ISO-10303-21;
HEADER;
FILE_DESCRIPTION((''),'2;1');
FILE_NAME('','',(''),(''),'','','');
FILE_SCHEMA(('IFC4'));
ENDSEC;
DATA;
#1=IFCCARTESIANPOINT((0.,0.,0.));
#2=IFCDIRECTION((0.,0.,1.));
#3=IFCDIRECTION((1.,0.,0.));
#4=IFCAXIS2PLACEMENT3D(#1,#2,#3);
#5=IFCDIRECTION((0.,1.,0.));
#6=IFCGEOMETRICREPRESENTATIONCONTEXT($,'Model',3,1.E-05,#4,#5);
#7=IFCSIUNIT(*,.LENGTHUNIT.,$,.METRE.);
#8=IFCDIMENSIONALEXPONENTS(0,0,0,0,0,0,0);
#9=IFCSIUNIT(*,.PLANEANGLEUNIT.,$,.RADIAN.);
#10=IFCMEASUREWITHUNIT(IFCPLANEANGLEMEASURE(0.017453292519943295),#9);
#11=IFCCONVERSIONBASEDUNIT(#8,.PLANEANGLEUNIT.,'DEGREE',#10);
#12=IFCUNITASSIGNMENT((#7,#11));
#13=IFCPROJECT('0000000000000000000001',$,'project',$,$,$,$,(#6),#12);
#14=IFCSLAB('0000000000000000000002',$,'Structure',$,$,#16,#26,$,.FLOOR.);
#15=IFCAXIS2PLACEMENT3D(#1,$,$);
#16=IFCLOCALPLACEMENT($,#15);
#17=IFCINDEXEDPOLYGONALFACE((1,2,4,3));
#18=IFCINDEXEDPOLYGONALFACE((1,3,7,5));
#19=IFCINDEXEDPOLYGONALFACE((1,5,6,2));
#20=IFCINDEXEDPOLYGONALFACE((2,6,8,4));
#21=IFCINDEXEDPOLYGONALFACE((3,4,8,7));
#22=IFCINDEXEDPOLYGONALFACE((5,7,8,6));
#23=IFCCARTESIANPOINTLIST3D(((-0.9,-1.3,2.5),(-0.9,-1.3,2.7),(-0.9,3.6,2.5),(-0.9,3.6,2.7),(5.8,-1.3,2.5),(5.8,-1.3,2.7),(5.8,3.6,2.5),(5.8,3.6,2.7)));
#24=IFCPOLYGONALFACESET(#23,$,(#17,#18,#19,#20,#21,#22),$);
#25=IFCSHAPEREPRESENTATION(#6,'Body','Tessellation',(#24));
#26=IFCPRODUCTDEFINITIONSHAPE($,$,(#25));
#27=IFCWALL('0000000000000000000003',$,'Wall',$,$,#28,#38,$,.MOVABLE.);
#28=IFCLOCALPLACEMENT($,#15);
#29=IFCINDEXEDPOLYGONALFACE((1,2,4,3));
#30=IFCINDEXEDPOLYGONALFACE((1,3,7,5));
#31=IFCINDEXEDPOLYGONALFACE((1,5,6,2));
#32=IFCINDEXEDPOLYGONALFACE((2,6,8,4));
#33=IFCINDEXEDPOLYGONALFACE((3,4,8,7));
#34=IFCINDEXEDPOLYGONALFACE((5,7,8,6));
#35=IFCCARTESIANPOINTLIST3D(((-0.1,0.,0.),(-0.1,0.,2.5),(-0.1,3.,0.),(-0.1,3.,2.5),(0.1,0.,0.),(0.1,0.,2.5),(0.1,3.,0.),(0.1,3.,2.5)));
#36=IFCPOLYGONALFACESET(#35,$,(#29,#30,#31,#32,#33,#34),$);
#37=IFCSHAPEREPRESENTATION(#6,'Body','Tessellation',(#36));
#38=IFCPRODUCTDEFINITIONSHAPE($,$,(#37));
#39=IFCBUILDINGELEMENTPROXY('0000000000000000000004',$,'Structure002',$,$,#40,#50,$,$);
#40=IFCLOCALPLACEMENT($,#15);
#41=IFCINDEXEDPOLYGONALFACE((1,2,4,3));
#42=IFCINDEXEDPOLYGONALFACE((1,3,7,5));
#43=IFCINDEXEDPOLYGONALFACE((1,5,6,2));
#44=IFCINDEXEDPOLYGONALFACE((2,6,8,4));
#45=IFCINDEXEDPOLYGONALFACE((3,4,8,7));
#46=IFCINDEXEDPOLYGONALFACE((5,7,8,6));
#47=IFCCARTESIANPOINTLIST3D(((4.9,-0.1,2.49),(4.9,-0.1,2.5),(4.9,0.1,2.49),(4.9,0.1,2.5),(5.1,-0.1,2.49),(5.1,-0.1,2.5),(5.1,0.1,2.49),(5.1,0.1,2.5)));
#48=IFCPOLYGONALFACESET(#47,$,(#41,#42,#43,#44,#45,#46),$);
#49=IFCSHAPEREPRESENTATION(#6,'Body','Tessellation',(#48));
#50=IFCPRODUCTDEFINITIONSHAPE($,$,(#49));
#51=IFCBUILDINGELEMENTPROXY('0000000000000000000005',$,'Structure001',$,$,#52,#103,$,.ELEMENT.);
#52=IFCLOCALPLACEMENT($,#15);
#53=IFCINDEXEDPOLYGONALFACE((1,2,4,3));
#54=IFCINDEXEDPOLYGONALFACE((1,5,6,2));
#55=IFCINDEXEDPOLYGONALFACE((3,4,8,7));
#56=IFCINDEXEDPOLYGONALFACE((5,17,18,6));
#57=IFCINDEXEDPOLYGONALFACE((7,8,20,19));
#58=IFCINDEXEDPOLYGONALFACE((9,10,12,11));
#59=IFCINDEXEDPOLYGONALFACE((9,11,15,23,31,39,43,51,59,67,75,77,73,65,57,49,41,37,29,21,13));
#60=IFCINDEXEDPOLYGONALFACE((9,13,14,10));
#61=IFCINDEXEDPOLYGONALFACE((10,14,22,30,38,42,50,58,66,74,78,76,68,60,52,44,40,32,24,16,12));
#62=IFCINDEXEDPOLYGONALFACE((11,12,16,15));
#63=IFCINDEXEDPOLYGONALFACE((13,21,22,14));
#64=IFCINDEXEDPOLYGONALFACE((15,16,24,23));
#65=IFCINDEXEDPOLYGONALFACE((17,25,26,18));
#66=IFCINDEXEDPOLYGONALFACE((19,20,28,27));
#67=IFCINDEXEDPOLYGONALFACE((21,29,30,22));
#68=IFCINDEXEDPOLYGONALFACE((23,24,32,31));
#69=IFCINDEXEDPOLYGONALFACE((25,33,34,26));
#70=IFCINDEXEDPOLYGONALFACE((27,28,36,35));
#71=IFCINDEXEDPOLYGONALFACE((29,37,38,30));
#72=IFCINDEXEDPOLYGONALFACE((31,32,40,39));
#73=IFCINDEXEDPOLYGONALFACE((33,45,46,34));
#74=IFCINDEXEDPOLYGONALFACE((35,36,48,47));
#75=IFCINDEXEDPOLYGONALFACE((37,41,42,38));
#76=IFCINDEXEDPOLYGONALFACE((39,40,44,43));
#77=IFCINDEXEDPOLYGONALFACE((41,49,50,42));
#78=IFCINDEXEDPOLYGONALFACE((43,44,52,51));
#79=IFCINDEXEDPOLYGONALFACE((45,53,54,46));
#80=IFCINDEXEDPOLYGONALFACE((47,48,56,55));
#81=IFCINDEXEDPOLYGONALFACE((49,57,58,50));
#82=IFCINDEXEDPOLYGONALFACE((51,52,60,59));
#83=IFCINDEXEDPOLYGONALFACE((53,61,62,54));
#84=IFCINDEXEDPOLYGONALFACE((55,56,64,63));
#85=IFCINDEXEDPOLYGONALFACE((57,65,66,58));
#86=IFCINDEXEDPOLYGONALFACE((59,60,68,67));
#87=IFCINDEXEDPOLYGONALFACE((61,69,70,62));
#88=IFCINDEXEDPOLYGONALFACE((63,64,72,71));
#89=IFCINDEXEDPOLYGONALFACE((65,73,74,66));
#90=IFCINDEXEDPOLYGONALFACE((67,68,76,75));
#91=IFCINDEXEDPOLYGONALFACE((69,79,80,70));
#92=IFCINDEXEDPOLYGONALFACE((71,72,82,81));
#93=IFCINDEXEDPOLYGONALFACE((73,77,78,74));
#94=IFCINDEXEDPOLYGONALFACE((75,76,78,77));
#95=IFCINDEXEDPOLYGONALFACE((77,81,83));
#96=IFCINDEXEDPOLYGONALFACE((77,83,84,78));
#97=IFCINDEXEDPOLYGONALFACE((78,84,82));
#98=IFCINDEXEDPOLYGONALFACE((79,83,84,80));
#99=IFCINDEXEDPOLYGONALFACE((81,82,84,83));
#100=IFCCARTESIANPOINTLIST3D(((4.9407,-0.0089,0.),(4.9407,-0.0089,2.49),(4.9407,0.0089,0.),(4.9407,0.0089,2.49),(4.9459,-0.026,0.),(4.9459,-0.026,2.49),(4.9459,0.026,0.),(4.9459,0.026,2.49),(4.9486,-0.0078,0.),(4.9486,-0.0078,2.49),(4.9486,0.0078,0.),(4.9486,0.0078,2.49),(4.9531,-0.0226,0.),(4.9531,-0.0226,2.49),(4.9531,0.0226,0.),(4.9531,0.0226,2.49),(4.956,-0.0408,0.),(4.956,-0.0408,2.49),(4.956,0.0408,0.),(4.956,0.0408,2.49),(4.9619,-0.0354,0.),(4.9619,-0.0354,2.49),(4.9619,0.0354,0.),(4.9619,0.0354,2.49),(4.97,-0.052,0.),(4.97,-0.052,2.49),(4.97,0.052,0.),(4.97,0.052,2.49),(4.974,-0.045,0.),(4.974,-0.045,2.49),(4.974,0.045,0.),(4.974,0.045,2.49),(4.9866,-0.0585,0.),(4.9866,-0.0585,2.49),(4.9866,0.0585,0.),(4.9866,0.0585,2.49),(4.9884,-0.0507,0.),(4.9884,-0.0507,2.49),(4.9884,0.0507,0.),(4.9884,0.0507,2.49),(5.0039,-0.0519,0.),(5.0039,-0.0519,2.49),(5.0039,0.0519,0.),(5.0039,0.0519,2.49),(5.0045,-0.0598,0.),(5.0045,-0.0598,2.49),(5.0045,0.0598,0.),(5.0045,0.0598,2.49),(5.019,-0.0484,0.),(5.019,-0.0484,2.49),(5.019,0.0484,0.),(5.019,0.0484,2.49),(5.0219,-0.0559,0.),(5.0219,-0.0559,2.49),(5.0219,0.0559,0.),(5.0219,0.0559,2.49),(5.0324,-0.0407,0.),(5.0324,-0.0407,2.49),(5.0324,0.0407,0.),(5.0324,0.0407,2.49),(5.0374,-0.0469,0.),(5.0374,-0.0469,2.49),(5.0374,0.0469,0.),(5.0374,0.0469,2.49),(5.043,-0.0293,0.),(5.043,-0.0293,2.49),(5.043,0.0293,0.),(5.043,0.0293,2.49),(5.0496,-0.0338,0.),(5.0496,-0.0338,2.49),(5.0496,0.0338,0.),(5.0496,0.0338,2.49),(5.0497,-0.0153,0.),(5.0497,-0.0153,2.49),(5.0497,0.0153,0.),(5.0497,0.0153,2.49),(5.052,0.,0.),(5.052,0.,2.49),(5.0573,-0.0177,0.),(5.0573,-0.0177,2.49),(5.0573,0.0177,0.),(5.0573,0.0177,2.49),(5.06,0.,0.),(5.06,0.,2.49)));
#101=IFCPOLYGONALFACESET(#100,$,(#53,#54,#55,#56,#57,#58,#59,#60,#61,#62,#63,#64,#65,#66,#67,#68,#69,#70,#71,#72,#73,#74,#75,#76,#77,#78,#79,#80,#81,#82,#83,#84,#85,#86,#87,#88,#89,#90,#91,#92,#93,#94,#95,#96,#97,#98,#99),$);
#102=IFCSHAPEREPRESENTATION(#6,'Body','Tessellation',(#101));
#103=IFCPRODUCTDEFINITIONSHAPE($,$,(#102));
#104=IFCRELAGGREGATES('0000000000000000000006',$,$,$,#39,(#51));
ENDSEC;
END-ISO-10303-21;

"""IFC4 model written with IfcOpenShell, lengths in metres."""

from ifc_helpers import new_model, entity, si_unit, converted_unit, direction, frame, origin_with_axes, place, context, project, polyline, circle_curve, parameter, trimmed, segment, composite_curve, outline, extrude, element, aggregate, save


model = new_model("IFC4")

# Units and contexts
model_context = context("Model", 3, precision=1e-05, world=origin_with_axes(), true_north=direction((0.0, 1.0, 0.0)))
ifc_project = project(units=[si_unit("LENGTHUNIT", "METRE"), converted_unit("PLANEANGLEUNIT", "DEGREE", entity("IfcPlaneAngleMeasure", 0.017453292519943295), si_unit("PLANEANGLEUNIT", "RADIAN"), dimensions=[0, 0, 0, 0, 0, 0, 0])], contexts=[model_context])

# Slab
placement = place(None, origin_with_axes())
element("IfcSlab", 1, at=placement, Name="Structure", PredefinedType="FLOOR", context=model_context, shape_type="SweptSolid", body=[
    extrude(outline(polyline([(3.35, -2.45), (3.35, 2.45), (-3.35, 2.45), (-3.35, -2.45), (3.35, -2.45)])), frame((2.45, 1.15, 2.5), z_axis=(0.0, 0.0, 1.0), x_axis=(1.0, 0.0, 0.0)), (0.0, 0.0, 1.0), 0.2),
])

# Wall
element("IfcWall", 2, at=placement, Name="Wall", PredefinedType="MOVABLE", context=model_context, shape_type="SweptSolid", body=[
    extrude(outline(polyline([(-0.1, 1.5), (-0.1, -1.5), (0.1, -1.5), (0.1, 1.5), (-0.1, 1.5)])), frame((0.0, 1.5, 0.0), z_axis=(0.0, 0.0, 1.0), x_axis=(1.0, 0.0, 0.0)), (0.0, 0.0, 1.0), 2.5),
])

# Building element proxies
proxy_1 = element("IfcBuildingElementProxy", 3, at=placement, Name="Structure002", context=model_context, shape_type="SweptSolid", body=[
    extrude(outline(polyline([(-0.1, -0.1), (0.1, -0.1), (0.1, 0.1), (-0.1, 0.1), (-0.1, -0.1)])), frame((5.0, 0.0, 2.49), z_axis=(0.0, 0.0, 1.0), x_axis=(1.0, 0.0, 0.0)), (0.0, 0.0, 1.0), 0.01),
])
proxy_2 = element("IfcBuildingElementProxy", 4, at=placement, Name="Structure001", PredefinedType="ELEMENT", context=model_context, shape_type="SweptSolid", body=[
    extrude(outline(composite_curve([segment(trimmed(circle_curve(frame((0.0, 0.0, 0.0), z_axis=(0.0, 0.0, 1.0), x_axis=(1.0, 0.0, 0.0)), 0.052), [parameter(0.0)], [parameter(0.0)], True, "PARAMETER"), True, "CONTINUOUS"), segment(polyline([(0.052, 0.0, 0.0), (0.06, 0.0, 0.0)]), True, "CONTINUOUS"), segment(trimmed(circle_curve(frame((0.0, 0.0, 0.0), z_axis=(0.0, 0.0, 1.0), x_axis=(1.0, 0.0, 0.0)), 0.06), [parameter(0.0)], [parameter(0.0)], True, "PARAMETER"), True, "CONTINUOUS")], self_intersect=False)), frame((5.0, 0.0, 0.0), z_axis=(0.0, 0.0, 1.0), x_axis=(1.0, 0.0, 0.0)), (0.0, 0.0, 1.0), 2.49),
])
aggregate(proxy_1, [proxy_2])

save(model, "model.ifc")
